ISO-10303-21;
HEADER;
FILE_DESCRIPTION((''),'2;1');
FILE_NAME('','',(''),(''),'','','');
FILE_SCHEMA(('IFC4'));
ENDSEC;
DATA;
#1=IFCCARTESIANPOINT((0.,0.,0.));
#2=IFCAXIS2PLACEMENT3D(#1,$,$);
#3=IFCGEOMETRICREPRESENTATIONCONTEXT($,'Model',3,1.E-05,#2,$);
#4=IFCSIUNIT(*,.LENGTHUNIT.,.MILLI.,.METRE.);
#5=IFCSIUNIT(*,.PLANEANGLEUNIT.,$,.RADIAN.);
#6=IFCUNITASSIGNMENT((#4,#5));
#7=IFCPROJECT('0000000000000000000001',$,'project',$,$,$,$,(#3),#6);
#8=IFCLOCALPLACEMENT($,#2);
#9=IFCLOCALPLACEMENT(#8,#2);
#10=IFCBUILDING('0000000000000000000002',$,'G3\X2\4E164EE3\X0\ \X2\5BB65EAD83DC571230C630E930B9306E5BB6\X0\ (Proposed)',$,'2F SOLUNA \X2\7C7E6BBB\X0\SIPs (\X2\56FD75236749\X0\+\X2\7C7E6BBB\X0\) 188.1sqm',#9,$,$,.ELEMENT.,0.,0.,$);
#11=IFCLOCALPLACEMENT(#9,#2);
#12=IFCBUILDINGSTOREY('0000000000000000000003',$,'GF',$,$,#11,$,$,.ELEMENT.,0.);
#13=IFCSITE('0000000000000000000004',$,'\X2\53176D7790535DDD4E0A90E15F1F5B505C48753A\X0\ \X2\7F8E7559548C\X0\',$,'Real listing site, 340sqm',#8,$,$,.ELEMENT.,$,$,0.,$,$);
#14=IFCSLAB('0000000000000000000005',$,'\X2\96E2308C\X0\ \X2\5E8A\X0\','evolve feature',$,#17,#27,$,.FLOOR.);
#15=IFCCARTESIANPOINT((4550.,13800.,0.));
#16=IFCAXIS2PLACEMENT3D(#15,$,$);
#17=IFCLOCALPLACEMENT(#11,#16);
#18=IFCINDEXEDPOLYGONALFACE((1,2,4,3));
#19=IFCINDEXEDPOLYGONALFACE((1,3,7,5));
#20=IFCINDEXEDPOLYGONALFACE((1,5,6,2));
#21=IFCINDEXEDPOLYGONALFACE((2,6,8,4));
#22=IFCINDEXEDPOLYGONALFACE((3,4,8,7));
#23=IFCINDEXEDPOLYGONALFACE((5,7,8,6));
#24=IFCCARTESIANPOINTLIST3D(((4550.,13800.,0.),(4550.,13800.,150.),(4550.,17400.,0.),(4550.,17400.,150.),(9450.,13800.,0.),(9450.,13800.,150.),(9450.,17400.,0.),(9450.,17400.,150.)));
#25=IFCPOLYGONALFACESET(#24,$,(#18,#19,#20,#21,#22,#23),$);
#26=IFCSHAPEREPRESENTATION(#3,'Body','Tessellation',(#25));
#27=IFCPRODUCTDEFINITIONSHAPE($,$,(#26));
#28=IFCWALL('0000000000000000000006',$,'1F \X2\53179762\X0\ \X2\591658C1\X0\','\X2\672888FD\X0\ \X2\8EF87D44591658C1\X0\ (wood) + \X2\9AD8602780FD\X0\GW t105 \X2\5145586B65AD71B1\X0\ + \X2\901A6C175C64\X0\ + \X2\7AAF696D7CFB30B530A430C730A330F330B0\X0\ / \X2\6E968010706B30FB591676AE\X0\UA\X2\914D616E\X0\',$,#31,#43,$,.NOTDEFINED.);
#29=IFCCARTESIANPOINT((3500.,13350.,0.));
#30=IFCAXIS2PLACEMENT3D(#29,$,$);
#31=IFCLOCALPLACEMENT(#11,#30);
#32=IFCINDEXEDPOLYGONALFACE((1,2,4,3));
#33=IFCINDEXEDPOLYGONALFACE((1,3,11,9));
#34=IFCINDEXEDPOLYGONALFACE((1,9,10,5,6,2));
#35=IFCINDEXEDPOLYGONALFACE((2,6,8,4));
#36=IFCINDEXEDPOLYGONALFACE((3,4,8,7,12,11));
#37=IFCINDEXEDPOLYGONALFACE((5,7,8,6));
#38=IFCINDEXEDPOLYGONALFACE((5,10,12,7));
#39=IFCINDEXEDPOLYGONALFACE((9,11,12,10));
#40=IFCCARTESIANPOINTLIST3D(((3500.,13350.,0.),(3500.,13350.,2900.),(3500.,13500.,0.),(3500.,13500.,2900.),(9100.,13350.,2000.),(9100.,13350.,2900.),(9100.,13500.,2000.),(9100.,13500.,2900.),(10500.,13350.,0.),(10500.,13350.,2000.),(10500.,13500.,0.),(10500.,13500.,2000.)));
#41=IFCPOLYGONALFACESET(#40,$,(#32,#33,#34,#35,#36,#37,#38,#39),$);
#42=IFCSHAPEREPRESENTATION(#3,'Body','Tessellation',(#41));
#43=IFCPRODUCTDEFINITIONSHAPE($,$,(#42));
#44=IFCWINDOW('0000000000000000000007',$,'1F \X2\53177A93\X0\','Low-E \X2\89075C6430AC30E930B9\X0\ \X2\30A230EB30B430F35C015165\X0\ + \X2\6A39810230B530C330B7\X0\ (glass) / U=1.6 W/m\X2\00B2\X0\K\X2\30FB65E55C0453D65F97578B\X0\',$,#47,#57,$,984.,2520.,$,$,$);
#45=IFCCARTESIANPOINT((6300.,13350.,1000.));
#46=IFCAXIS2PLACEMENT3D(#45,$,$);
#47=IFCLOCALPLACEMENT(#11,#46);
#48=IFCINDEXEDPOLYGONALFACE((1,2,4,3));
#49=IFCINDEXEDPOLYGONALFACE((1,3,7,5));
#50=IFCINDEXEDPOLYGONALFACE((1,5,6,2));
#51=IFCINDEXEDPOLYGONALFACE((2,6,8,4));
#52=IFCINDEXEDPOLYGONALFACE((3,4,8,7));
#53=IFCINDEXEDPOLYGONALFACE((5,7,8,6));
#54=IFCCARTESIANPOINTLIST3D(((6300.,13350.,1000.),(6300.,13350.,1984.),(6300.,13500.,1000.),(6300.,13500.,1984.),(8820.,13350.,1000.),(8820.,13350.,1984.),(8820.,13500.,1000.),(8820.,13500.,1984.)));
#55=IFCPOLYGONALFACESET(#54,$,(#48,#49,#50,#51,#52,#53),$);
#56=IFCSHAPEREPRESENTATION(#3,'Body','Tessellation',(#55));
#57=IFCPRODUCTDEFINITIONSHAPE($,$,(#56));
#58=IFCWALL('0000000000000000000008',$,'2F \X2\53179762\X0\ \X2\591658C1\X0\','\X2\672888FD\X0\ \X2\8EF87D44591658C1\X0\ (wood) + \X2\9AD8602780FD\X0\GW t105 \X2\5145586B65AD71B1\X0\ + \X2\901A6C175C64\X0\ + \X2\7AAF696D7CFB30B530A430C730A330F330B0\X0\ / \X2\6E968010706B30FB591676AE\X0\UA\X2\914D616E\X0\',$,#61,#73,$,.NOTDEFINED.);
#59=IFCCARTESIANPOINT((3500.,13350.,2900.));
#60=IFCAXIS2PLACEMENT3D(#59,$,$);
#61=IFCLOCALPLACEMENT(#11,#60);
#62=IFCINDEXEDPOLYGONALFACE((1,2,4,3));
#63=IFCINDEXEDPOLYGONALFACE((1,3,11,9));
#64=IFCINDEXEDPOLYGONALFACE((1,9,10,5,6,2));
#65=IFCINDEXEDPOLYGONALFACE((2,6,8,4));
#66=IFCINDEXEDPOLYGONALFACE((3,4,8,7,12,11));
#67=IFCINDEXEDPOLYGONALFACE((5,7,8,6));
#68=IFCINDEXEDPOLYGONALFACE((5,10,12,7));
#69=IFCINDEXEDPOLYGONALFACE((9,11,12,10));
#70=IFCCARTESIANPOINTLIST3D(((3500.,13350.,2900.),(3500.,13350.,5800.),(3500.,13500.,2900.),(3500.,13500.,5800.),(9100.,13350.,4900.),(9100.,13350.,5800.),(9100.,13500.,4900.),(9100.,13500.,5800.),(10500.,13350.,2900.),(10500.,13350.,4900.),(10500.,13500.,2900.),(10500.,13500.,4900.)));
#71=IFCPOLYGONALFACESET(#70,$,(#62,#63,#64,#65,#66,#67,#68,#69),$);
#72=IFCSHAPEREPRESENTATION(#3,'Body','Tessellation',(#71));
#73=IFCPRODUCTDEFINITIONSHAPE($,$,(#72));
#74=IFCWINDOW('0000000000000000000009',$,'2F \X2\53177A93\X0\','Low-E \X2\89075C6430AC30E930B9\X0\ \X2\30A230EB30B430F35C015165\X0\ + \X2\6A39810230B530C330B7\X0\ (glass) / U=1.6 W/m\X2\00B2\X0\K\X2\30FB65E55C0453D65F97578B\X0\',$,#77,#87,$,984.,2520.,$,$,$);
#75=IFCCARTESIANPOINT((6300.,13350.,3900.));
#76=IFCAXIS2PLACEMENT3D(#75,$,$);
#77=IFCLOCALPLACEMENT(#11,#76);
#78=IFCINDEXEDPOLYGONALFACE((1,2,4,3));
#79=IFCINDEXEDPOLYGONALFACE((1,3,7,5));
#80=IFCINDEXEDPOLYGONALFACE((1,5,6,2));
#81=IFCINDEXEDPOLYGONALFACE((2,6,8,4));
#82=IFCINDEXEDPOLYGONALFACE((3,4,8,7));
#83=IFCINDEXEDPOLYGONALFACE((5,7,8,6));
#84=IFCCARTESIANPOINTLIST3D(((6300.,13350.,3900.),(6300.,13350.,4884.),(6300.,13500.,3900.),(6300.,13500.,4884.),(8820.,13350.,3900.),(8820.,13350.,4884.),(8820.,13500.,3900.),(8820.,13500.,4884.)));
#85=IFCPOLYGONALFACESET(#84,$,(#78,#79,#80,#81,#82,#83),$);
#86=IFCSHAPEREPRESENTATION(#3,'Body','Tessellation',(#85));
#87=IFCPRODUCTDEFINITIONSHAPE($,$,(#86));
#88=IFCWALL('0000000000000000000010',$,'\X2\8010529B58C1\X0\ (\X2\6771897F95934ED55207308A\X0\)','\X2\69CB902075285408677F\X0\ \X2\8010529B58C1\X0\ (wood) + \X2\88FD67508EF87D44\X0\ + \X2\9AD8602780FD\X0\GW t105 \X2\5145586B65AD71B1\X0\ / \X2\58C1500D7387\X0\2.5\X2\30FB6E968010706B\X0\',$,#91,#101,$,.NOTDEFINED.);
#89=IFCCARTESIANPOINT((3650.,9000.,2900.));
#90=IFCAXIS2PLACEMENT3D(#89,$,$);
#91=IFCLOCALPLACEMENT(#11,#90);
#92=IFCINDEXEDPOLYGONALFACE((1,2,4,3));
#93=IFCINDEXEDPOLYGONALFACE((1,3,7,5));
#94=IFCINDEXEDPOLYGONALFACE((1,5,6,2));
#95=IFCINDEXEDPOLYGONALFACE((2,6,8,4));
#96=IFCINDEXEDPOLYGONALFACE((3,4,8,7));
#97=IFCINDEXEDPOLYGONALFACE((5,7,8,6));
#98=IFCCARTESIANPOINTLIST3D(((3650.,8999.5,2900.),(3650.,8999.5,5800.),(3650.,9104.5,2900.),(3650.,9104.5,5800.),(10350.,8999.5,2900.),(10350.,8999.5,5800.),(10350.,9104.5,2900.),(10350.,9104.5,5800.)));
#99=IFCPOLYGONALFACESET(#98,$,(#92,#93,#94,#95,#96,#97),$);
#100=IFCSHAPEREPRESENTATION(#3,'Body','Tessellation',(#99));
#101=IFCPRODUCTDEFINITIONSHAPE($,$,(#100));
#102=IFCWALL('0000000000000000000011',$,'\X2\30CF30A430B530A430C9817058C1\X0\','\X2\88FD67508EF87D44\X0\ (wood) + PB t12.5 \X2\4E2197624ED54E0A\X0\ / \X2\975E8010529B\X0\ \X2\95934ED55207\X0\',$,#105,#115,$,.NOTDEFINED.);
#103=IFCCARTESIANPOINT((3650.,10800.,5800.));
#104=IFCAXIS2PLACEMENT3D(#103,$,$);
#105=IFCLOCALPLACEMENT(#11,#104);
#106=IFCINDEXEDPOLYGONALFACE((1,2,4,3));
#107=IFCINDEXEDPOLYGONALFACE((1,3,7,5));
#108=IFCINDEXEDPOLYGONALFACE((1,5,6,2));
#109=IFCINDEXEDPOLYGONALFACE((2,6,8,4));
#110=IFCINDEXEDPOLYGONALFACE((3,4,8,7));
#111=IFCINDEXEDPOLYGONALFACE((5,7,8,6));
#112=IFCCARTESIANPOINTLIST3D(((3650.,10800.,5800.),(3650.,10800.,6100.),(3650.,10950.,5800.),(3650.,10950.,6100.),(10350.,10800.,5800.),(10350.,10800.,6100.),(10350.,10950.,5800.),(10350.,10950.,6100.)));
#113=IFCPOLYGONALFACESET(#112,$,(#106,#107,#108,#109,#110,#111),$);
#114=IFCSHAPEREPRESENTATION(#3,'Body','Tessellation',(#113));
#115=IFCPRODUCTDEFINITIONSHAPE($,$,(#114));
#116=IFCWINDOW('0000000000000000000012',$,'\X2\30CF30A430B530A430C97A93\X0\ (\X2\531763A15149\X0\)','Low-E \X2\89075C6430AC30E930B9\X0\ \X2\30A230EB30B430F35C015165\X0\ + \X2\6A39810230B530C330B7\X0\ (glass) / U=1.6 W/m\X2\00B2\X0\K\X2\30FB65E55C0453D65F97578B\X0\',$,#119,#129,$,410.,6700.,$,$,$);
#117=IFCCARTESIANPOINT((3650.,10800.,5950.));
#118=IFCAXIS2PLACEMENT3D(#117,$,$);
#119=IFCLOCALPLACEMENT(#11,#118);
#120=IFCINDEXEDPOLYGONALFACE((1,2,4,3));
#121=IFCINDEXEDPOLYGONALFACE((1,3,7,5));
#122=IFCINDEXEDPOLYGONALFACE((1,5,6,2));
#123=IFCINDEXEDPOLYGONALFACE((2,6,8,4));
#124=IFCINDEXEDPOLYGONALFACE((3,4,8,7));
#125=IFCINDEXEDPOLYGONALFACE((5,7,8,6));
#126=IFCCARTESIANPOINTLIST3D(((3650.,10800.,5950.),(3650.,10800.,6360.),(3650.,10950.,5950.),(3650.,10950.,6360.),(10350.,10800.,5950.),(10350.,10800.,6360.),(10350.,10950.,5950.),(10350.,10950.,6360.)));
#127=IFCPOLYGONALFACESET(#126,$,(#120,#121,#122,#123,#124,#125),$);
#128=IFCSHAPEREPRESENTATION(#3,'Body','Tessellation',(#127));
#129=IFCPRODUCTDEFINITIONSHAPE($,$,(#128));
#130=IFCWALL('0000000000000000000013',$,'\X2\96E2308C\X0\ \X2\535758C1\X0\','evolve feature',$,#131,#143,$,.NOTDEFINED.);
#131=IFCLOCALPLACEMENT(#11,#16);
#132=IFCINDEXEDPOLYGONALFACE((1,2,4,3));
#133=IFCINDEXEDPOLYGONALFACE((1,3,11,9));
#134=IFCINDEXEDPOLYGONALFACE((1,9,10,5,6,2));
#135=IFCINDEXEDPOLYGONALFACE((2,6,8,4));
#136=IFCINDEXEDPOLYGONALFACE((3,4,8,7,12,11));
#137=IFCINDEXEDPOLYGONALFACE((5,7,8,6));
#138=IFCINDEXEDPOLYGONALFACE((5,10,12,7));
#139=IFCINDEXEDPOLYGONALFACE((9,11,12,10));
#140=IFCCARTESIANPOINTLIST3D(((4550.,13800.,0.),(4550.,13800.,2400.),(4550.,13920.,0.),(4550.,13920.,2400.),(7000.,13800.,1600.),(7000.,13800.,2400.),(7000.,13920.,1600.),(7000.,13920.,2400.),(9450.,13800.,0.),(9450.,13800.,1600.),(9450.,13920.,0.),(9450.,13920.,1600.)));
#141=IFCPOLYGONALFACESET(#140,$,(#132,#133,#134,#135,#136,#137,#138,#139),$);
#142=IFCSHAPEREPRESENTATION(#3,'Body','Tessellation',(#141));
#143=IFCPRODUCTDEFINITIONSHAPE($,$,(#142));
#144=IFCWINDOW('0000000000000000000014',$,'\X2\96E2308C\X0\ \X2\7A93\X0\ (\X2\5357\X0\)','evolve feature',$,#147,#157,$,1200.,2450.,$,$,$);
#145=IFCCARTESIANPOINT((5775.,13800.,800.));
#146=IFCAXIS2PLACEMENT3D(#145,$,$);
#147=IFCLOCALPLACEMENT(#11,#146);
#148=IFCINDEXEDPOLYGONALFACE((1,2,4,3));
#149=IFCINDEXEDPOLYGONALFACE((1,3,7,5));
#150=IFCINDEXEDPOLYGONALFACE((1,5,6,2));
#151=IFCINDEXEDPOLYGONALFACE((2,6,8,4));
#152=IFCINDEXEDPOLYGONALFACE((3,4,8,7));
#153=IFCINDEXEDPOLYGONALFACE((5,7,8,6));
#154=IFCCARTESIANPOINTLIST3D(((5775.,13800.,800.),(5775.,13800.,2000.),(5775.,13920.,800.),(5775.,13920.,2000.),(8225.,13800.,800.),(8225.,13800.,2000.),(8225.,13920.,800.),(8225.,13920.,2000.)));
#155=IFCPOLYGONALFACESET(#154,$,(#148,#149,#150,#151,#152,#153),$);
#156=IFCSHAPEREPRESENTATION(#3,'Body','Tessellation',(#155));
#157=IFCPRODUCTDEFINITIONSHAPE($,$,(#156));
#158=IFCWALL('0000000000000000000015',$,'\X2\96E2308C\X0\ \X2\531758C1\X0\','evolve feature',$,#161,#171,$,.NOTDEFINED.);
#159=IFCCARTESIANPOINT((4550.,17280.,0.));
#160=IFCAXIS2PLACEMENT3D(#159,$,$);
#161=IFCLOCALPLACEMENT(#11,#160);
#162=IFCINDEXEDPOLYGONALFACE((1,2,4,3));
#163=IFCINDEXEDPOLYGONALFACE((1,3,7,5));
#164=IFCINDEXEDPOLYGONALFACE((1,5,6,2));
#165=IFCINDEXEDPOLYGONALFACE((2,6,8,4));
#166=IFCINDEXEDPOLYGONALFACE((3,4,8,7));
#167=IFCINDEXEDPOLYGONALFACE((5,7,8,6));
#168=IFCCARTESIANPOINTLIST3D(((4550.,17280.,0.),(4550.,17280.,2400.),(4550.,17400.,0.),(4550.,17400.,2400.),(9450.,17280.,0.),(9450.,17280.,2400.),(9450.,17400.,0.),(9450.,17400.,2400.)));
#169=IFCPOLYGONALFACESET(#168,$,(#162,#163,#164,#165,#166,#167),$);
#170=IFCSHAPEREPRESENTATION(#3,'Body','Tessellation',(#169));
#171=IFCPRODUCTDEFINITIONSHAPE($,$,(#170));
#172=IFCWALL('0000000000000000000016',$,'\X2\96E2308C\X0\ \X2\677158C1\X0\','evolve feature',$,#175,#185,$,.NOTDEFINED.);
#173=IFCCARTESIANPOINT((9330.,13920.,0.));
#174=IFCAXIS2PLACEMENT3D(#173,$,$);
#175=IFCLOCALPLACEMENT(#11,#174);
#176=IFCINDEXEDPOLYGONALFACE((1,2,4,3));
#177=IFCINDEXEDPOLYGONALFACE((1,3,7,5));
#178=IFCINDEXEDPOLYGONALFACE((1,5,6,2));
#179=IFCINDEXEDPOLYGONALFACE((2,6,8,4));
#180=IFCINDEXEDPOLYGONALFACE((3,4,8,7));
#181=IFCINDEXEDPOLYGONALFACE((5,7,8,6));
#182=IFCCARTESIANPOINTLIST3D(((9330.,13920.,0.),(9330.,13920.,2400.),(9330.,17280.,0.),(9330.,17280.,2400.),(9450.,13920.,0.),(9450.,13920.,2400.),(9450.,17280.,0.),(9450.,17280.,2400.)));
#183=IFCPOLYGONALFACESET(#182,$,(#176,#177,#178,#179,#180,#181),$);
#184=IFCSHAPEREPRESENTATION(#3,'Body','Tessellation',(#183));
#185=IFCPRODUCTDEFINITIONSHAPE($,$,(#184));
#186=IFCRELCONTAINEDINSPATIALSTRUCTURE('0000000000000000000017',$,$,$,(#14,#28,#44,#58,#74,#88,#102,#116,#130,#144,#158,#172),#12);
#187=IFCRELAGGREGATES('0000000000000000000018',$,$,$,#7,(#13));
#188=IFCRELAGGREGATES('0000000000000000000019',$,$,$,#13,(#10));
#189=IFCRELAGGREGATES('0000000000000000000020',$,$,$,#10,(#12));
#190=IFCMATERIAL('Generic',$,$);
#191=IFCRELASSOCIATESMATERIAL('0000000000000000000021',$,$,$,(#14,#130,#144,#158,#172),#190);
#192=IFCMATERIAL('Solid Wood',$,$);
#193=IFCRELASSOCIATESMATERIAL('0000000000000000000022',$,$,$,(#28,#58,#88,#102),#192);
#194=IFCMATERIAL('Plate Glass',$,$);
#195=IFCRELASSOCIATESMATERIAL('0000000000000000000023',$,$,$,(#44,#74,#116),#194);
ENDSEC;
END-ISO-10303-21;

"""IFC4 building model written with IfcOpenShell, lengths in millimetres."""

from ifc_helpers import new_model, si_unit, frame, frame_2d, origin, place, context, project, spatial, rectangle, extrude, material, element, fill, save


model = new_model("IFC4")

# Units and contexts
model_context = context("Model", 3, precision=1e-05, world=origin())
ifc_project = project(units=[si_unit("LENGTHUNIT", "METRE", prefix="MILLI"), si_unit("PLANEANGLEUNIT", "RADIAN")], contexts=[model_context])

# Site, building, storey
site_placement = place(None, origin())
site = spatial("IfcSite", under=ifc_project, at=site_placement, Name="北海道川上郡弟子屈町 美留和", ObjectType="Real listing site, 340sqm", CompositionType="ELEMENT", RefElevation=0.0)
building_placement = place(site_placement, origin())
building = spatial("IfcBuilding", under=site, at=building_placement, Name="G3世代 家庭菜園テラスの家 (Proposed)", ObjectType="2F SOLUNA 籾殻SIPs (国産杉+籾殻) 188.1sqm", CompositionType="ELEMENT", ElevationOfRefHeight=0.0, ElevationOfTerrain=0.0)
storey_placement = place(building_placement, origin())
storey = spatial("IfcBuildingStorey", under=building, at=storey_placement, Name="GF", CompositionType="ELEMENT", Elevation=0.0)

# Slab
ifc_material_1 = material(Name="Generic")
slab_placement = place(storey_placement, frame((4550.0, 13800.0, 0.0)))
element("IfcSlab", 1, at=slab_placement, inside=storey, material=ifc_material_1, Name="離れ 床", Description="evolve feature", PredefinedType="FLOOR", context=model_context, shape_type="SweptSolid", body=[
    extrude(rectangle(XDim=4900.0, YDim=3600.0, at=frame_2d((2450.0, 1800.0))), frame((4550.0, 13800.0, 0.0)), (0.0, 0.0, 1.0), 150.0),
])

# Wall, opening, window
ifc_material_2 = material(Name="Solid Wood")
wall_1_placement = place(storey_placement, frame((3500.0, 13350.0, 0.0)))
wall_1 = element("IfcWall", 2, at=wall_1_placement, inside=storey, material=ifc_material_2, Name="1F 北面 外壁", Description="木製 軸組外壁 (wood) + 高性能GW t105 充填断熱 + 通気層 + 窯業系サイディング / 準耐火・外皮UA配慮", PredefinedType="NOTDEFINED", context=model_context, shape_type="SweptSolid", body=[
    extrude(rectangle(XDim=7000.0, YDim=150.0, at=frame_2d((3500.0, 75.0))), frame((3500.0, 13350.0, 0.0)), (0.0, 0.0, 1.0), 2900.0),
])
opening_1_placement = place(storey_placement, frame((6300.0, 13350.0, 1000.0)))
opening_1 = element("IfcOpeningElement", 3, at=opening_1_placement, cuts=wall_1, PredefinedType="NOTDEFINED", context=model_context, shape_type="SweptSolid", body=[
    extrude(rectangle(XDim=2520.0, YDim=150.0, at=frame_2d((1260.0, 75.0))), frame((6300.0, 13350.0, 1000.0)), (0.0, 0.0, 1.0), 984.0),
])
ifc_material_3 = material(Name="Plate Glass")
window_1_placement = place(storey_placement, frame((6300.0, 13350.0, 1000.0)))
window_1 = element("IfcWindow", 4, at=window_1_placement, inside=storey, material=ifc_material_3, Name="1F 北窓", Description="Low-E 複層ガラス アルゴン封入 + 樹脂サッシ (glass) / U=1.6 W/m²K・日射取得型", OverallHeight=984.0, OverallWidth=2520.0, context=model_context, shape_type="SweptSolid", body=[
    extrude(rectangle(XDim=2520.0, YDim=150.0, at=frame_2d((1260.0, 75.0))), frame((6300.0, 13350.0, 1000.0)), (0.0, 0.0, 1.0), 984.0),
])
fill(opening_1, window_1)

# Wall, opening, window
wall_2_placement = place(storey_placement, frame((3500.0, 13350.0, 2900.0)))
wall_2 = element("IfcWall", 5, at=wall_2_placement, inside=storey, material=ifc_material_2, Name="2F 北面 外壁", Description="木製 軸組外壁 (wood) + 高性能GW t105 充填断熱 + 通気層 + 窯業系サイディング / 準耐火・外皮UA配慮", PredefinedType="NOTDEFINED", context=model_context, shape_type="SweptSolid", body=[
    extrude(rectangle(XDim=7000.0, YDim=150.0, at=frame_2d((3500.0, 75.0))), frame((3500.0, 13350.0, 2900.0)), (0.0, 0.0, 1.0), 2900.0),
])
opening_2_placement = place(storey_placement, frame((6300.0, 13350.0, 3900.0)))
opening_2 = element("IfcOpeningElement", 6, at=opening_2_placement, cuts=wall_2, PredefinedType="NOTDEFINED", context=model_context, shape_type="SweptSolid", body=[
    extrude(rectangle(XDim=2520.0, YDim=150.0, at=frame_2d((1260.0, 75.0))), frame((6300.0, 13350.0, 3900.0)), (0.0, 0.0, 1.0), 984.0),
])
window_2_placement = place(storey_placement, frame((6300.0, 13350.0, 3900.0)))
window_2 = element("IfcWindow", 7, at=window_2_placement, inside=storey, material=ifc_material_3, Name="2F 北窓", Description="Low-E 複層ガラス アルゴン封入 + 樹脂サッシ (glass) / U=1.6 W/m²K・日射取得型", OverallHeight=984.0, OverallWidth=2520.0, context=model_context, shape_type="SweptSolid", body=[
    extrude(rectangle(XDim=2520.0, YDim=150.0, at=frame_2d((1260.0, 75.0))), frame((6300.0, 13350.0, 3900.0)), (0.0, 0.0, 1.0), 984.0),
])
fill(opening_2, window_2)

# Wall
wall_3_placement = place(storey_placement, frame((3650.0, 9000.0, 2900.0)))
element("IfcWall", 8, at=wall_3_placement, inside=storey, material=ifc_material_2, Name="耐力壁 (東西間仕切り)", Description="構造用合板 耐力壁 (wood) + 製材軸組 + 高性能GW t105 充填断熱 / 壁倍率2.5・準耐火", PredefinedType="NOTDEFINED", context=model_context, shape_type="SweptSolid", body=[
    extrude(rectangle(XDim=6700.0, YDim=105.0, at=frame_2d((3350.0, 52.0))), frame((3650.0, 9000.0, 2900.0)), (0.0, 0.0, 1.0), 2900.0),
])

# Walls, openings, windows
wall_4_placement = place(storey_placement, frame((3650.0, 10800.0, 5800.0)))
wall_4 = element("IfcWall", 9, at=wall_4_placement, inside=storey, material=ifc_material_2, Name="ハイサイド腰壁", Description="製材軸組 (wood) + PB t12.5 両面仕上 / 非耐力 間仕切", PredefinedType="NOTDEFINED", context=model_context, shape_type="SweptSolid", body=[
    extrude(rectangle(XDim=6700.0, YDim=150.0, at=frame_2d((3350.0, 75.0))), frame((3650.0, 10800.0, 5800.0)), (0.0, 0.0, 1.0), 700.0),
])
opening_3_placement = place(storey_placement, frame((3650.0, 10800.0, 5950.0)))
opening_3 = element("IfcOpeningElement", 10, at=opening_3_placement, cuts=wall_4, PredefinedType="NOTDEFINED", context=model_context, shape_type="SweptSolid", body=[
    extrude(rectangle(XDim=6700.0, YDim=150.0, at=frame_2d((3350.0, 75.0))), frame((3650.0, 10800.0, 5950.0)), (0.0, 0.0, 1.0), 410.0),
])
window_3_placement = place(storey_placement, frame((3650.0, 10800.0, 5950.0)))
window_3 = element("IfcWindow", 11, at=window_3_placement, inside=storey, material=ifc_material_3, Name="ハイサイド窓 (北採光)", Description="Low-E 複層ガラス アルゴン封入 + 樹脂サッシ (glass) / U=1.6 W/m²K・日射取得型", OverallHeight=410.0, OverallWidth=6700.0, context=model_context, shape_type="SweptSolid", body=[
    extrude(rectangle(XDim=6700.0, YDim=150.0, at=frame_2d((3350.0, 75.0))), frame((3650.0, 10800.0, 5950.0)), (0.0, 0.0, 1.0), 410.0),
])
fill(opening_3, window_3)
wall_5_placement = place(storey_placement, frame((4550.0, 13800.0, 0.0)))
wall_5 = element("IfcWall", 12, at=wall_5_placement, inside=storey, material=ifc_material_1, Name="離れ 南壁", Description="evolve feature", PredefinedType="NOTDEFINED", context=model_context, shape_type="SweptSolid", body=[
    extrude(rectangle(XDim=4900.0, YDim=120.0, at=frame_2d((2450.0, 60.0))), frame((4550.0, 13800.0, 0.0)), (0.0, 0.0, 1.0), 2400.0),
])
opening_4_placement = place(storey_placement, frame((5775.0, 13800.0, 800.0)))
opening_4 = element("IfcOpeningElement", 13, at=opening_4_placement, cuts=wall_5, PredefinedType="NOTDEFINED", context=model_context, shape_type="SweptSolid", body=[
    extrude(rectangle(XDim=2450.0, YDim=120.0, at=frame_2d((1225.0, 60.0))), frame((5775.0, 13800.0, 800.0)), (0.0, 0.0, 1.0), 1200.0),
])
window_4_placement = place(storey_placement, frame((5775.0, 13800.0, 800.0)))
window_4 = element("IfcWindow", 14, at=window_4_placement, inside=storey, material=ifc_material_1, Name="離れ 窓 (南)", Description="evolve feature", OverallHeight=1200.0, OverallWidth=2450.0, context=model_context, shape_type="SweptSolid", body=[
    extrude(rectangle(XDim=2450.0, YDim=120.0, at=frame_2d((1225.0, 60.0))), frame((5775.0, 13800.0, 800.0)), (0.0, 0.0, 1.0), 1200.0),
])
fill(opening_4, window_4)

# Walls
wall_6_placement = place(storey_placement, frame((4550.0, 17280.0, 0.0)))
element("IfcWall", 15, at=wall_6_placement, inside=storey, material=ifc_material_1, Name="離れ 北壁", Description="evolve feature", PredefinedType="NOTDEFINED", context=model_context, shape_type="SweptSolid", body=[
    extrude(rectangle(XDim=4900.0, YDim=120.0, at=frame_2d((2450.0, 60.0))), frame((4550.0, 17280.0, 0.0)), (0.0, 0.0, 1.0), 2400.0),
])
wall_7_placement = place(storey_placement, frame((9330.0, 13920.0, 0.0)))
element("IfcWall", 16, at=wall_7_placement, inside=storey, material=ifc_material_1, Name="離れ 東壁", Description="evolve feature", PredefinedType="NOTDEFINED", context=model_context, shape_type="SweptSolid", body=[
    extrude(rectangle(XDim=120.0, YDim=3360.0, at=frame_2d((60.0, 1680.0))), frame((9330.0, 13920.0, 0.0)), (0.0, 0.0, 1.0), 2400.0),
])

save(model, "model.ifc")
